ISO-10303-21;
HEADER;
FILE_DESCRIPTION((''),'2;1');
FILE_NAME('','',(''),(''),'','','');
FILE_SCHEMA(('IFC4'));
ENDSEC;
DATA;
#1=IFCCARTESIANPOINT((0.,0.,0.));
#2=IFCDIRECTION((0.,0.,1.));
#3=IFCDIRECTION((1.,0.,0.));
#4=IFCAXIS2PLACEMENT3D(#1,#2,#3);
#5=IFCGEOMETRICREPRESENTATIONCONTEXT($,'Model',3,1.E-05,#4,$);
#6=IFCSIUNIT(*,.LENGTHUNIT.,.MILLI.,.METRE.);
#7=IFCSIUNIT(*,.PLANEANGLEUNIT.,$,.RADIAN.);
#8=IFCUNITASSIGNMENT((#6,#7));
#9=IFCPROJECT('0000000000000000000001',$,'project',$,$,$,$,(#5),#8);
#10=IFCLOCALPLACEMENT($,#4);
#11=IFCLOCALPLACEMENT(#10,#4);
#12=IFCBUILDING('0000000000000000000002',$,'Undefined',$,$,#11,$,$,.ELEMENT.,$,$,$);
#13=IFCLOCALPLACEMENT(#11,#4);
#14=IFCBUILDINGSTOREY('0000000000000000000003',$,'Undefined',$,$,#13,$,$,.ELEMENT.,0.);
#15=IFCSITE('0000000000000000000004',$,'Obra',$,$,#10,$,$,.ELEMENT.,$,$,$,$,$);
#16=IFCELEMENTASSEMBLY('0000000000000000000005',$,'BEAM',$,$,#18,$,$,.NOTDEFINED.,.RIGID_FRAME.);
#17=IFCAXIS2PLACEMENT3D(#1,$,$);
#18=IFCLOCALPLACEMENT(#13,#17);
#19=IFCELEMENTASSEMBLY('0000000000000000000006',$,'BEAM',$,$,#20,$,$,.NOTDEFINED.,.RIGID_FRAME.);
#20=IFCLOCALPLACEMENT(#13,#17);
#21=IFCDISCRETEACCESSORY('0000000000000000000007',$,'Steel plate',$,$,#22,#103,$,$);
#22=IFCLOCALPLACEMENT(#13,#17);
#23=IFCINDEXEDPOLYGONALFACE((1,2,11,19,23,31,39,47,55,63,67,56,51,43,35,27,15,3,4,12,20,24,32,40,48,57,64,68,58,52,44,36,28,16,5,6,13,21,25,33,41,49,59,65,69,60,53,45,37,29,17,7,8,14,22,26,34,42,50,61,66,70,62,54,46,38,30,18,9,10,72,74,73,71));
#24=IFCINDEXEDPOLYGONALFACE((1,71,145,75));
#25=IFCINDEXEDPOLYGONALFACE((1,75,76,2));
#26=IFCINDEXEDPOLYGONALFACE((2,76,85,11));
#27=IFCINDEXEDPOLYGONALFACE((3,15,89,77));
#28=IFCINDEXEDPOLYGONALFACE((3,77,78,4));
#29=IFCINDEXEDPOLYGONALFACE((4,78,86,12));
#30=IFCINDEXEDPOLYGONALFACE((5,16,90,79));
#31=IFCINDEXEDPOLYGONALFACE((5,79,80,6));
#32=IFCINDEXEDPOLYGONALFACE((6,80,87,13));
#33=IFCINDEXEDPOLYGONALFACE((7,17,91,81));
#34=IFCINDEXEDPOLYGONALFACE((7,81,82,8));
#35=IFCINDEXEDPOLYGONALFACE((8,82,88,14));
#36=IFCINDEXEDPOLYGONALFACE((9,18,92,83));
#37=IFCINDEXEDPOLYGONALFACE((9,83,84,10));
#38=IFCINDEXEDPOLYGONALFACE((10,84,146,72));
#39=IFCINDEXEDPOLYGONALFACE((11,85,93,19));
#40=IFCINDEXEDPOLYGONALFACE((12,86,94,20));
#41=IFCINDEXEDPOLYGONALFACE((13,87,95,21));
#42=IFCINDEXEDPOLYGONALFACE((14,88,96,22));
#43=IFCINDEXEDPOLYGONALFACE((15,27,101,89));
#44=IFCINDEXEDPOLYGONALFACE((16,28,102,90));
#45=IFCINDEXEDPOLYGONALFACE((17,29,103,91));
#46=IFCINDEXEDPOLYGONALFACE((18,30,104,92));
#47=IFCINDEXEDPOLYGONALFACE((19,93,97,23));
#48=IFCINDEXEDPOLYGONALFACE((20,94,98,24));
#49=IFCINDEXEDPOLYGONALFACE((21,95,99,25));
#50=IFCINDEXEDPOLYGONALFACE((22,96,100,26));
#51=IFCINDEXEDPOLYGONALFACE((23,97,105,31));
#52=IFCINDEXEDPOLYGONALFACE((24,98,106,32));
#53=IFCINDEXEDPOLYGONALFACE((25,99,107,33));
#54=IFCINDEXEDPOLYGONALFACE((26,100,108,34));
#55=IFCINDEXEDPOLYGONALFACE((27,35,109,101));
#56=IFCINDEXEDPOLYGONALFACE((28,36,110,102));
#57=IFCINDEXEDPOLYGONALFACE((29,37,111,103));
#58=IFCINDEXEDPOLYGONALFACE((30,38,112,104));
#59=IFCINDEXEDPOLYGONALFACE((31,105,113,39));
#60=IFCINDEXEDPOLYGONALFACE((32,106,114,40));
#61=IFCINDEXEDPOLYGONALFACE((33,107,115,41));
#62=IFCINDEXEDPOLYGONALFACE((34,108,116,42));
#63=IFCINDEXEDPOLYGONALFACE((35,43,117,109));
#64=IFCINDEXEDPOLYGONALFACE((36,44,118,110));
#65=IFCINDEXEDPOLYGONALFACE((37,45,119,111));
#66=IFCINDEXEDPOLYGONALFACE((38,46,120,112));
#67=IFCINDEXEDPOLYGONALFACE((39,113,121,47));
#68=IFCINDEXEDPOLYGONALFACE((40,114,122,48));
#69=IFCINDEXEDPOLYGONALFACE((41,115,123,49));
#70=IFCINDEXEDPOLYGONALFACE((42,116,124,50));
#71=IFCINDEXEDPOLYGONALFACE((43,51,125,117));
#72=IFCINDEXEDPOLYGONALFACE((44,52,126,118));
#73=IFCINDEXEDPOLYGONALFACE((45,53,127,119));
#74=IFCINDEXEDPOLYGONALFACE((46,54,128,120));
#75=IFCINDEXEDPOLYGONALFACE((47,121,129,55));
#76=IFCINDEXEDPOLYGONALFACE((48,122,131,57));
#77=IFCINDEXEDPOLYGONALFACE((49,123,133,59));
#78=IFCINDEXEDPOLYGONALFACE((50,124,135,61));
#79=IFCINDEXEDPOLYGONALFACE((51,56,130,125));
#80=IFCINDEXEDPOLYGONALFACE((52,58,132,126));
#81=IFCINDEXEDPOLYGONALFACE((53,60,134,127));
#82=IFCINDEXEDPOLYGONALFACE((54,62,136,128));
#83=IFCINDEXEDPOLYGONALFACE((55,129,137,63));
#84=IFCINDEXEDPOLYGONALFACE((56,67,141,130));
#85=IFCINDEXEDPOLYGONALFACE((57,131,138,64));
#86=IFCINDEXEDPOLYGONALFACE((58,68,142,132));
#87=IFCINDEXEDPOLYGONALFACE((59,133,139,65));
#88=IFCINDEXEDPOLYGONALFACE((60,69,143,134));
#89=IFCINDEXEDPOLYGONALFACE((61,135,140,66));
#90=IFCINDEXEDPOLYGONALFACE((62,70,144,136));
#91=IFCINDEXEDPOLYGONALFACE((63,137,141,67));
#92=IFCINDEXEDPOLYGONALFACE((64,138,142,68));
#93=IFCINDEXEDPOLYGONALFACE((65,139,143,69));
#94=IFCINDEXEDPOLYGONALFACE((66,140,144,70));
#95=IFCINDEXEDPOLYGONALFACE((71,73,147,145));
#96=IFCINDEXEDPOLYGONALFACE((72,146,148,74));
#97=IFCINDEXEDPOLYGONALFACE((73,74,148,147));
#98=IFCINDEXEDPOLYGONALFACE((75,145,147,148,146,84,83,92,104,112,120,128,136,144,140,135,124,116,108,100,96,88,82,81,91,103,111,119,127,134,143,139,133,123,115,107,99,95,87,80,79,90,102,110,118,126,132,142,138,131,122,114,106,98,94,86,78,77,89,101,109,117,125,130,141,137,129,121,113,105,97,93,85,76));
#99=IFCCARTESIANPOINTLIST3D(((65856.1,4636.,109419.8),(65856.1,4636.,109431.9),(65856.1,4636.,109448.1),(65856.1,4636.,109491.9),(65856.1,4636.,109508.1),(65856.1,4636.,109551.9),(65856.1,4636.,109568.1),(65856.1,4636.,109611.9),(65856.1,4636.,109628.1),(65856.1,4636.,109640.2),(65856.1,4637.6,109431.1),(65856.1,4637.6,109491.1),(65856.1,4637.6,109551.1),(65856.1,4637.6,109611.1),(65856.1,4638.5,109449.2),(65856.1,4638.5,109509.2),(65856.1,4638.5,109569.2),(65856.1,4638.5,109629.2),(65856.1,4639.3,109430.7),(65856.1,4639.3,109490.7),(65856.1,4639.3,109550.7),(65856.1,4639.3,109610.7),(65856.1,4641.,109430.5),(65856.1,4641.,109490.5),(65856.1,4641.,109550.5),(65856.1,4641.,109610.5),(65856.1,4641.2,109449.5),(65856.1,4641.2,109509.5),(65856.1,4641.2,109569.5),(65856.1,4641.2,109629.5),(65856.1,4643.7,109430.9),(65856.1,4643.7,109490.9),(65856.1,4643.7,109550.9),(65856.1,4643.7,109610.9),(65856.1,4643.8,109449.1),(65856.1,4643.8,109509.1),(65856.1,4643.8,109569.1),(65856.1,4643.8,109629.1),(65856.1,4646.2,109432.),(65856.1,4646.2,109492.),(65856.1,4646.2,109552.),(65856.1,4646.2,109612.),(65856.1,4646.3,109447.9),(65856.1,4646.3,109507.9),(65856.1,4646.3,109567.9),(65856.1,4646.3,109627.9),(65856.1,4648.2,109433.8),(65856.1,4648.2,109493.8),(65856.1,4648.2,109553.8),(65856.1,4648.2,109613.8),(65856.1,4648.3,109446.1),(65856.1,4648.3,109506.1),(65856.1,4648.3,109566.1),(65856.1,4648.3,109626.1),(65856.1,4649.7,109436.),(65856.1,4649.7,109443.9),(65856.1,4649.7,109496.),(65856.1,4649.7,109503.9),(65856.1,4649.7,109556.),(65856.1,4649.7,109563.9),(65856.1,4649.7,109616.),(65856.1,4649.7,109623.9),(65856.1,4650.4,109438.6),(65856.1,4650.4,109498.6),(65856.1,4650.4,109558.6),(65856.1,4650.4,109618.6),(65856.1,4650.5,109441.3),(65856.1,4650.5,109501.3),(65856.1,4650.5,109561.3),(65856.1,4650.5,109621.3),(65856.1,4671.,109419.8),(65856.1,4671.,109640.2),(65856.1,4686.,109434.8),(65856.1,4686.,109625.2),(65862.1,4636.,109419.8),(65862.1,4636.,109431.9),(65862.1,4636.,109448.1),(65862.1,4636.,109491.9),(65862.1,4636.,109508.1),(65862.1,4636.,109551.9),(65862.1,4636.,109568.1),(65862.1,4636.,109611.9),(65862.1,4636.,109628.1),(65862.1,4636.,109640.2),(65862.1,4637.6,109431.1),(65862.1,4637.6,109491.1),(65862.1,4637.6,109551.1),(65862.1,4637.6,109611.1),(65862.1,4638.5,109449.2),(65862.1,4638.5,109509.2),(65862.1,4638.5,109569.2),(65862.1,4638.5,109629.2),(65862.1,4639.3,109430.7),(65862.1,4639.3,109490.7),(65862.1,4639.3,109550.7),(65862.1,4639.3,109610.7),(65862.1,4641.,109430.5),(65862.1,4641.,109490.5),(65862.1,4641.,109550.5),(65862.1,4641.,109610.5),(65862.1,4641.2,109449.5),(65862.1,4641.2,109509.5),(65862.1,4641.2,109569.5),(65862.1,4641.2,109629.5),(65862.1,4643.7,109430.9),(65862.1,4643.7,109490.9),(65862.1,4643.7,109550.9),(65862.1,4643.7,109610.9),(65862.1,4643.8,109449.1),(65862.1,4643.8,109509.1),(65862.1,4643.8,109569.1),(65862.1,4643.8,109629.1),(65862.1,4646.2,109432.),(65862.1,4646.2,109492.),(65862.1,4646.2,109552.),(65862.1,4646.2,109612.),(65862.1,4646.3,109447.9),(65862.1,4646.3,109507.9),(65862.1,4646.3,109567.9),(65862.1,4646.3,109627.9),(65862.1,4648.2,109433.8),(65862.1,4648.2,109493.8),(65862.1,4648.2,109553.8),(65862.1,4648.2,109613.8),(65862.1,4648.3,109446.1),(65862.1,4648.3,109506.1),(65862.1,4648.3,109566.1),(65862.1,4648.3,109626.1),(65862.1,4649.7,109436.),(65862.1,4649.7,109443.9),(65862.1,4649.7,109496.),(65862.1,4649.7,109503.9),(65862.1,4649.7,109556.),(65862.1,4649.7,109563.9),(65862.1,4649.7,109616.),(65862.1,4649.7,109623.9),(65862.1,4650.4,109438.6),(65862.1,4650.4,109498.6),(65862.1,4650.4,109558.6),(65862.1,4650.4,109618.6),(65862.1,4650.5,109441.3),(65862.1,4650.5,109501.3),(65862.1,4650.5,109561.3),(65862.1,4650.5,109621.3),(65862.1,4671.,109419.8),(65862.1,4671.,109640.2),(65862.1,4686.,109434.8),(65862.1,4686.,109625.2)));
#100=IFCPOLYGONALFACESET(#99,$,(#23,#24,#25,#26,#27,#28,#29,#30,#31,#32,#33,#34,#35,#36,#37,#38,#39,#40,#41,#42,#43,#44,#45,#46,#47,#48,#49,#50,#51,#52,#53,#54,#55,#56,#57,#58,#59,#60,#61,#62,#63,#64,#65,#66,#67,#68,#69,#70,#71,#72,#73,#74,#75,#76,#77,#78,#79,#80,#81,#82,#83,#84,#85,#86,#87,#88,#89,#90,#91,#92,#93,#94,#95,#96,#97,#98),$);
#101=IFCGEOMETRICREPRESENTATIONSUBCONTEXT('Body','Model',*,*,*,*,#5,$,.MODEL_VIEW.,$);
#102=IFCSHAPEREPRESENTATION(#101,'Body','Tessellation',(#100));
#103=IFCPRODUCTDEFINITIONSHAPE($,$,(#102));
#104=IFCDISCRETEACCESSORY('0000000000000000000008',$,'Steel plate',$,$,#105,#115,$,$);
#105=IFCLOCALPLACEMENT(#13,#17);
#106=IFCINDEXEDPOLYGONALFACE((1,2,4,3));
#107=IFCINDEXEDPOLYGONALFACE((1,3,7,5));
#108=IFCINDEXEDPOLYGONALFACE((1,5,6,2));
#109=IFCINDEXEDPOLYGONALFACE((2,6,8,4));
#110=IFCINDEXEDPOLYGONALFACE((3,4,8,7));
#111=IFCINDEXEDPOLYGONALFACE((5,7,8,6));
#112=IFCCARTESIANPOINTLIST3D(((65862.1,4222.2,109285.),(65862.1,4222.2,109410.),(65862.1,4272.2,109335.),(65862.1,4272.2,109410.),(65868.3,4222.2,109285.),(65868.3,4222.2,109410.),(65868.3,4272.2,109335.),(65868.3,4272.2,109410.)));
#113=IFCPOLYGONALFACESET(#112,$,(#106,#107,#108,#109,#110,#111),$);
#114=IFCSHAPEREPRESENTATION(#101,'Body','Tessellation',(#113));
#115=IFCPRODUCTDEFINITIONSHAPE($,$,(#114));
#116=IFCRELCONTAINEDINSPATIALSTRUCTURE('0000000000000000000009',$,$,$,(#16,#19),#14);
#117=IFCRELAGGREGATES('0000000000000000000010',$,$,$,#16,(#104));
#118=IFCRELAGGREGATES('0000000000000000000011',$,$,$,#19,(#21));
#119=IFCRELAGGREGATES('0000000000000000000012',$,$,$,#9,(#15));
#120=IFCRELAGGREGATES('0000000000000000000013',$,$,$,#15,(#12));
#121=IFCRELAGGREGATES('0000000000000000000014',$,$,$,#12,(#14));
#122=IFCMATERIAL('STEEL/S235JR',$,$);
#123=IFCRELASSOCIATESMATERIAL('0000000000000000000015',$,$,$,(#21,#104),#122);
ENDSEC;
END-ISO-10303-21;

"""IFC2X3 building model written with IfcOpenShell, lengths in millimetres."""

from ifc_helpers import new_model, si_unit, frame, origin_with_axes, origin_2d_with_axis, place, context, subcontext, project, spatial, polyline, circle, outline, extrude, source, transform, mapped, material, element, aggregate, save


model = new_model("IFC2X3")

# Units and contexts
model_context = context("Model", 3, precision=1e-05, world=origin_with_axes())
body_context = subcontext(model_context, "Body", "Model", "MODEL_VIEW")
ifc_project = project(units=[si_unit("LENGTHUNIT", "METRE", prefix="MILLI"), si_unit("PLANEANGLEUNIT", "RADIAN")], contexts=[model_context])

# Site, building, storey
site_placement = place(None, origin_with_axes())
site = spatial("IfcSite", under=ifc_project, at=site_placement, Name="Obra", CompositionType="ELEMENT")
building_placement = place(site_placement, origin_with_axes())
building = spatial("IfcBuilding", under=site, at=building_placement, Name="Undefined", CompositionType="ELEMENT")
storey_placement = place(building_placement, origin_with_axes())
storey = spatial("IfcBuildingStorey", under=building, at=storey_placement, Name="Undefined", CompositionType="ELEMENT", Elevation=0.0)

# Shared definitions
ifc_material_1 = material(Name="STEEL/S235JR")

# Shared definitions
shared_shape_1 = source(origin_with_axes(), body_context, "Body", "SweptSolid", [
    extrude(circle(Radius=9.5, at=origin_2d_with_axis()), frame((0.0, -9.2, 0.0), z_axis=(0.0, 1.0, 0.0), x_axis=(1.0, 0.0, 0.0)), (0.0, 0.0, 1.0), 6.2),
])

# Element assembly
assembly_1_placement = place(storey_placement, origin_with_axes())
assembly_1 = element("IfcElementAssembly", 1, at=assembly_1_placement, inside=storey, Name="BEAM", AssemblyPlace="NOTDEFINED", PredefinedType="RIGID_FRAME")

# Element assembly, discrete accessory, opening
assembly_2_placement = place(storey_placement, origin_with_axes())
assembly_2 = element("IfcElementAssembly", 2, at=assembly_2_placement, inside=storey, Name="BEAM", AssemblyPlace="NOTDEFINED", PredefinedType="RIGID_FRAME")
discrete_accessory_1_placement = place(assembly_2_placement, frame((65859.1, 4636.0, 109419.8), z_axis=(1.0, 0.0, 0.0), x_axis=(0.0, 1.0, 0.0)))
discrete_accessory_1 = element("IfcDiscreteAccessory", 3, at=discrete_accessory_1_placement, material=ifc_material_1, Name="Steel plate", context=body_context, shape_type="SweptSolid", body=[
    extrude(outline(polyline([(0.0, 0.0), (35.0, 0.0), (50.0, 15.0), (50.0, 205.4), (35.0, 220.4), (0.0, 220.4), (0.0, 0.0)])), frame((0.0, 0.0, -3.0), z_axis=(0.0, 0.0, 1.0), x_axis=(1.0, 0.0, 0.0)), (0.0, 0.0, 1.0), 6.0),
])
opening_1_placement = place(assembly_2_placement, frame((65865.2, 4676.0, 109650.0), z_axis=(0.0, -1.0, 0.0), x_axis=(0.0, 0.0, -1.0)))
element("IfcOpeningElement", 4, at=opening_1_placement, cuts=discrete_accessory_1, ObjectType="Opening", context=body_context, shape_type="MappedRepresentation", body=[
    mapped(shared_shape_1, transform((30.0, 0.0, 35.0))),
    mapped(shared_shape_1, transform((90.0, 0.0, 35.0))),
    mapped(shared_shape_1, transform((150.0, 0.0, 35.0))),
    mapped(shared_shape_1, transform((210.0, 0.0, 35.0))),
])

# Discrete accessory
discrete_accessory_2_placement = place(assembly_1_placement, frame((65865.2, 4222.2, 109410.0), z_axis=(1.0, 0.0, 0.0), x_axis=(0.0, 0.0, -1.0)))
discrete_accessory_2 = element("IfcDiscreteAccessory", 5, at=discrete_accessory_2_placement, material=ifc_material_1, Name="Steel plate", context=body_context, shape_type="SweptSolid", body=[
    extrude(outline(polyline([(0.0, 0.0), (150.0, 0.0), (150.0, -25.0), (75.0, 50.0), (0.0, 50.0), (0.0, 0.0)])), frame((0.0, 0.0, -3.1), z_axis=(0.0, 0.0, 1.0), x_axis=(1.0, 0.0, 0.0)), (0.0, 0.0, 1.0), 6.2),
])
aggregate(assembly_1, [discrete_accessory_2])

aggregate(assembly_2, [discrete_accessory_1])

save(model, "model.ifc")
